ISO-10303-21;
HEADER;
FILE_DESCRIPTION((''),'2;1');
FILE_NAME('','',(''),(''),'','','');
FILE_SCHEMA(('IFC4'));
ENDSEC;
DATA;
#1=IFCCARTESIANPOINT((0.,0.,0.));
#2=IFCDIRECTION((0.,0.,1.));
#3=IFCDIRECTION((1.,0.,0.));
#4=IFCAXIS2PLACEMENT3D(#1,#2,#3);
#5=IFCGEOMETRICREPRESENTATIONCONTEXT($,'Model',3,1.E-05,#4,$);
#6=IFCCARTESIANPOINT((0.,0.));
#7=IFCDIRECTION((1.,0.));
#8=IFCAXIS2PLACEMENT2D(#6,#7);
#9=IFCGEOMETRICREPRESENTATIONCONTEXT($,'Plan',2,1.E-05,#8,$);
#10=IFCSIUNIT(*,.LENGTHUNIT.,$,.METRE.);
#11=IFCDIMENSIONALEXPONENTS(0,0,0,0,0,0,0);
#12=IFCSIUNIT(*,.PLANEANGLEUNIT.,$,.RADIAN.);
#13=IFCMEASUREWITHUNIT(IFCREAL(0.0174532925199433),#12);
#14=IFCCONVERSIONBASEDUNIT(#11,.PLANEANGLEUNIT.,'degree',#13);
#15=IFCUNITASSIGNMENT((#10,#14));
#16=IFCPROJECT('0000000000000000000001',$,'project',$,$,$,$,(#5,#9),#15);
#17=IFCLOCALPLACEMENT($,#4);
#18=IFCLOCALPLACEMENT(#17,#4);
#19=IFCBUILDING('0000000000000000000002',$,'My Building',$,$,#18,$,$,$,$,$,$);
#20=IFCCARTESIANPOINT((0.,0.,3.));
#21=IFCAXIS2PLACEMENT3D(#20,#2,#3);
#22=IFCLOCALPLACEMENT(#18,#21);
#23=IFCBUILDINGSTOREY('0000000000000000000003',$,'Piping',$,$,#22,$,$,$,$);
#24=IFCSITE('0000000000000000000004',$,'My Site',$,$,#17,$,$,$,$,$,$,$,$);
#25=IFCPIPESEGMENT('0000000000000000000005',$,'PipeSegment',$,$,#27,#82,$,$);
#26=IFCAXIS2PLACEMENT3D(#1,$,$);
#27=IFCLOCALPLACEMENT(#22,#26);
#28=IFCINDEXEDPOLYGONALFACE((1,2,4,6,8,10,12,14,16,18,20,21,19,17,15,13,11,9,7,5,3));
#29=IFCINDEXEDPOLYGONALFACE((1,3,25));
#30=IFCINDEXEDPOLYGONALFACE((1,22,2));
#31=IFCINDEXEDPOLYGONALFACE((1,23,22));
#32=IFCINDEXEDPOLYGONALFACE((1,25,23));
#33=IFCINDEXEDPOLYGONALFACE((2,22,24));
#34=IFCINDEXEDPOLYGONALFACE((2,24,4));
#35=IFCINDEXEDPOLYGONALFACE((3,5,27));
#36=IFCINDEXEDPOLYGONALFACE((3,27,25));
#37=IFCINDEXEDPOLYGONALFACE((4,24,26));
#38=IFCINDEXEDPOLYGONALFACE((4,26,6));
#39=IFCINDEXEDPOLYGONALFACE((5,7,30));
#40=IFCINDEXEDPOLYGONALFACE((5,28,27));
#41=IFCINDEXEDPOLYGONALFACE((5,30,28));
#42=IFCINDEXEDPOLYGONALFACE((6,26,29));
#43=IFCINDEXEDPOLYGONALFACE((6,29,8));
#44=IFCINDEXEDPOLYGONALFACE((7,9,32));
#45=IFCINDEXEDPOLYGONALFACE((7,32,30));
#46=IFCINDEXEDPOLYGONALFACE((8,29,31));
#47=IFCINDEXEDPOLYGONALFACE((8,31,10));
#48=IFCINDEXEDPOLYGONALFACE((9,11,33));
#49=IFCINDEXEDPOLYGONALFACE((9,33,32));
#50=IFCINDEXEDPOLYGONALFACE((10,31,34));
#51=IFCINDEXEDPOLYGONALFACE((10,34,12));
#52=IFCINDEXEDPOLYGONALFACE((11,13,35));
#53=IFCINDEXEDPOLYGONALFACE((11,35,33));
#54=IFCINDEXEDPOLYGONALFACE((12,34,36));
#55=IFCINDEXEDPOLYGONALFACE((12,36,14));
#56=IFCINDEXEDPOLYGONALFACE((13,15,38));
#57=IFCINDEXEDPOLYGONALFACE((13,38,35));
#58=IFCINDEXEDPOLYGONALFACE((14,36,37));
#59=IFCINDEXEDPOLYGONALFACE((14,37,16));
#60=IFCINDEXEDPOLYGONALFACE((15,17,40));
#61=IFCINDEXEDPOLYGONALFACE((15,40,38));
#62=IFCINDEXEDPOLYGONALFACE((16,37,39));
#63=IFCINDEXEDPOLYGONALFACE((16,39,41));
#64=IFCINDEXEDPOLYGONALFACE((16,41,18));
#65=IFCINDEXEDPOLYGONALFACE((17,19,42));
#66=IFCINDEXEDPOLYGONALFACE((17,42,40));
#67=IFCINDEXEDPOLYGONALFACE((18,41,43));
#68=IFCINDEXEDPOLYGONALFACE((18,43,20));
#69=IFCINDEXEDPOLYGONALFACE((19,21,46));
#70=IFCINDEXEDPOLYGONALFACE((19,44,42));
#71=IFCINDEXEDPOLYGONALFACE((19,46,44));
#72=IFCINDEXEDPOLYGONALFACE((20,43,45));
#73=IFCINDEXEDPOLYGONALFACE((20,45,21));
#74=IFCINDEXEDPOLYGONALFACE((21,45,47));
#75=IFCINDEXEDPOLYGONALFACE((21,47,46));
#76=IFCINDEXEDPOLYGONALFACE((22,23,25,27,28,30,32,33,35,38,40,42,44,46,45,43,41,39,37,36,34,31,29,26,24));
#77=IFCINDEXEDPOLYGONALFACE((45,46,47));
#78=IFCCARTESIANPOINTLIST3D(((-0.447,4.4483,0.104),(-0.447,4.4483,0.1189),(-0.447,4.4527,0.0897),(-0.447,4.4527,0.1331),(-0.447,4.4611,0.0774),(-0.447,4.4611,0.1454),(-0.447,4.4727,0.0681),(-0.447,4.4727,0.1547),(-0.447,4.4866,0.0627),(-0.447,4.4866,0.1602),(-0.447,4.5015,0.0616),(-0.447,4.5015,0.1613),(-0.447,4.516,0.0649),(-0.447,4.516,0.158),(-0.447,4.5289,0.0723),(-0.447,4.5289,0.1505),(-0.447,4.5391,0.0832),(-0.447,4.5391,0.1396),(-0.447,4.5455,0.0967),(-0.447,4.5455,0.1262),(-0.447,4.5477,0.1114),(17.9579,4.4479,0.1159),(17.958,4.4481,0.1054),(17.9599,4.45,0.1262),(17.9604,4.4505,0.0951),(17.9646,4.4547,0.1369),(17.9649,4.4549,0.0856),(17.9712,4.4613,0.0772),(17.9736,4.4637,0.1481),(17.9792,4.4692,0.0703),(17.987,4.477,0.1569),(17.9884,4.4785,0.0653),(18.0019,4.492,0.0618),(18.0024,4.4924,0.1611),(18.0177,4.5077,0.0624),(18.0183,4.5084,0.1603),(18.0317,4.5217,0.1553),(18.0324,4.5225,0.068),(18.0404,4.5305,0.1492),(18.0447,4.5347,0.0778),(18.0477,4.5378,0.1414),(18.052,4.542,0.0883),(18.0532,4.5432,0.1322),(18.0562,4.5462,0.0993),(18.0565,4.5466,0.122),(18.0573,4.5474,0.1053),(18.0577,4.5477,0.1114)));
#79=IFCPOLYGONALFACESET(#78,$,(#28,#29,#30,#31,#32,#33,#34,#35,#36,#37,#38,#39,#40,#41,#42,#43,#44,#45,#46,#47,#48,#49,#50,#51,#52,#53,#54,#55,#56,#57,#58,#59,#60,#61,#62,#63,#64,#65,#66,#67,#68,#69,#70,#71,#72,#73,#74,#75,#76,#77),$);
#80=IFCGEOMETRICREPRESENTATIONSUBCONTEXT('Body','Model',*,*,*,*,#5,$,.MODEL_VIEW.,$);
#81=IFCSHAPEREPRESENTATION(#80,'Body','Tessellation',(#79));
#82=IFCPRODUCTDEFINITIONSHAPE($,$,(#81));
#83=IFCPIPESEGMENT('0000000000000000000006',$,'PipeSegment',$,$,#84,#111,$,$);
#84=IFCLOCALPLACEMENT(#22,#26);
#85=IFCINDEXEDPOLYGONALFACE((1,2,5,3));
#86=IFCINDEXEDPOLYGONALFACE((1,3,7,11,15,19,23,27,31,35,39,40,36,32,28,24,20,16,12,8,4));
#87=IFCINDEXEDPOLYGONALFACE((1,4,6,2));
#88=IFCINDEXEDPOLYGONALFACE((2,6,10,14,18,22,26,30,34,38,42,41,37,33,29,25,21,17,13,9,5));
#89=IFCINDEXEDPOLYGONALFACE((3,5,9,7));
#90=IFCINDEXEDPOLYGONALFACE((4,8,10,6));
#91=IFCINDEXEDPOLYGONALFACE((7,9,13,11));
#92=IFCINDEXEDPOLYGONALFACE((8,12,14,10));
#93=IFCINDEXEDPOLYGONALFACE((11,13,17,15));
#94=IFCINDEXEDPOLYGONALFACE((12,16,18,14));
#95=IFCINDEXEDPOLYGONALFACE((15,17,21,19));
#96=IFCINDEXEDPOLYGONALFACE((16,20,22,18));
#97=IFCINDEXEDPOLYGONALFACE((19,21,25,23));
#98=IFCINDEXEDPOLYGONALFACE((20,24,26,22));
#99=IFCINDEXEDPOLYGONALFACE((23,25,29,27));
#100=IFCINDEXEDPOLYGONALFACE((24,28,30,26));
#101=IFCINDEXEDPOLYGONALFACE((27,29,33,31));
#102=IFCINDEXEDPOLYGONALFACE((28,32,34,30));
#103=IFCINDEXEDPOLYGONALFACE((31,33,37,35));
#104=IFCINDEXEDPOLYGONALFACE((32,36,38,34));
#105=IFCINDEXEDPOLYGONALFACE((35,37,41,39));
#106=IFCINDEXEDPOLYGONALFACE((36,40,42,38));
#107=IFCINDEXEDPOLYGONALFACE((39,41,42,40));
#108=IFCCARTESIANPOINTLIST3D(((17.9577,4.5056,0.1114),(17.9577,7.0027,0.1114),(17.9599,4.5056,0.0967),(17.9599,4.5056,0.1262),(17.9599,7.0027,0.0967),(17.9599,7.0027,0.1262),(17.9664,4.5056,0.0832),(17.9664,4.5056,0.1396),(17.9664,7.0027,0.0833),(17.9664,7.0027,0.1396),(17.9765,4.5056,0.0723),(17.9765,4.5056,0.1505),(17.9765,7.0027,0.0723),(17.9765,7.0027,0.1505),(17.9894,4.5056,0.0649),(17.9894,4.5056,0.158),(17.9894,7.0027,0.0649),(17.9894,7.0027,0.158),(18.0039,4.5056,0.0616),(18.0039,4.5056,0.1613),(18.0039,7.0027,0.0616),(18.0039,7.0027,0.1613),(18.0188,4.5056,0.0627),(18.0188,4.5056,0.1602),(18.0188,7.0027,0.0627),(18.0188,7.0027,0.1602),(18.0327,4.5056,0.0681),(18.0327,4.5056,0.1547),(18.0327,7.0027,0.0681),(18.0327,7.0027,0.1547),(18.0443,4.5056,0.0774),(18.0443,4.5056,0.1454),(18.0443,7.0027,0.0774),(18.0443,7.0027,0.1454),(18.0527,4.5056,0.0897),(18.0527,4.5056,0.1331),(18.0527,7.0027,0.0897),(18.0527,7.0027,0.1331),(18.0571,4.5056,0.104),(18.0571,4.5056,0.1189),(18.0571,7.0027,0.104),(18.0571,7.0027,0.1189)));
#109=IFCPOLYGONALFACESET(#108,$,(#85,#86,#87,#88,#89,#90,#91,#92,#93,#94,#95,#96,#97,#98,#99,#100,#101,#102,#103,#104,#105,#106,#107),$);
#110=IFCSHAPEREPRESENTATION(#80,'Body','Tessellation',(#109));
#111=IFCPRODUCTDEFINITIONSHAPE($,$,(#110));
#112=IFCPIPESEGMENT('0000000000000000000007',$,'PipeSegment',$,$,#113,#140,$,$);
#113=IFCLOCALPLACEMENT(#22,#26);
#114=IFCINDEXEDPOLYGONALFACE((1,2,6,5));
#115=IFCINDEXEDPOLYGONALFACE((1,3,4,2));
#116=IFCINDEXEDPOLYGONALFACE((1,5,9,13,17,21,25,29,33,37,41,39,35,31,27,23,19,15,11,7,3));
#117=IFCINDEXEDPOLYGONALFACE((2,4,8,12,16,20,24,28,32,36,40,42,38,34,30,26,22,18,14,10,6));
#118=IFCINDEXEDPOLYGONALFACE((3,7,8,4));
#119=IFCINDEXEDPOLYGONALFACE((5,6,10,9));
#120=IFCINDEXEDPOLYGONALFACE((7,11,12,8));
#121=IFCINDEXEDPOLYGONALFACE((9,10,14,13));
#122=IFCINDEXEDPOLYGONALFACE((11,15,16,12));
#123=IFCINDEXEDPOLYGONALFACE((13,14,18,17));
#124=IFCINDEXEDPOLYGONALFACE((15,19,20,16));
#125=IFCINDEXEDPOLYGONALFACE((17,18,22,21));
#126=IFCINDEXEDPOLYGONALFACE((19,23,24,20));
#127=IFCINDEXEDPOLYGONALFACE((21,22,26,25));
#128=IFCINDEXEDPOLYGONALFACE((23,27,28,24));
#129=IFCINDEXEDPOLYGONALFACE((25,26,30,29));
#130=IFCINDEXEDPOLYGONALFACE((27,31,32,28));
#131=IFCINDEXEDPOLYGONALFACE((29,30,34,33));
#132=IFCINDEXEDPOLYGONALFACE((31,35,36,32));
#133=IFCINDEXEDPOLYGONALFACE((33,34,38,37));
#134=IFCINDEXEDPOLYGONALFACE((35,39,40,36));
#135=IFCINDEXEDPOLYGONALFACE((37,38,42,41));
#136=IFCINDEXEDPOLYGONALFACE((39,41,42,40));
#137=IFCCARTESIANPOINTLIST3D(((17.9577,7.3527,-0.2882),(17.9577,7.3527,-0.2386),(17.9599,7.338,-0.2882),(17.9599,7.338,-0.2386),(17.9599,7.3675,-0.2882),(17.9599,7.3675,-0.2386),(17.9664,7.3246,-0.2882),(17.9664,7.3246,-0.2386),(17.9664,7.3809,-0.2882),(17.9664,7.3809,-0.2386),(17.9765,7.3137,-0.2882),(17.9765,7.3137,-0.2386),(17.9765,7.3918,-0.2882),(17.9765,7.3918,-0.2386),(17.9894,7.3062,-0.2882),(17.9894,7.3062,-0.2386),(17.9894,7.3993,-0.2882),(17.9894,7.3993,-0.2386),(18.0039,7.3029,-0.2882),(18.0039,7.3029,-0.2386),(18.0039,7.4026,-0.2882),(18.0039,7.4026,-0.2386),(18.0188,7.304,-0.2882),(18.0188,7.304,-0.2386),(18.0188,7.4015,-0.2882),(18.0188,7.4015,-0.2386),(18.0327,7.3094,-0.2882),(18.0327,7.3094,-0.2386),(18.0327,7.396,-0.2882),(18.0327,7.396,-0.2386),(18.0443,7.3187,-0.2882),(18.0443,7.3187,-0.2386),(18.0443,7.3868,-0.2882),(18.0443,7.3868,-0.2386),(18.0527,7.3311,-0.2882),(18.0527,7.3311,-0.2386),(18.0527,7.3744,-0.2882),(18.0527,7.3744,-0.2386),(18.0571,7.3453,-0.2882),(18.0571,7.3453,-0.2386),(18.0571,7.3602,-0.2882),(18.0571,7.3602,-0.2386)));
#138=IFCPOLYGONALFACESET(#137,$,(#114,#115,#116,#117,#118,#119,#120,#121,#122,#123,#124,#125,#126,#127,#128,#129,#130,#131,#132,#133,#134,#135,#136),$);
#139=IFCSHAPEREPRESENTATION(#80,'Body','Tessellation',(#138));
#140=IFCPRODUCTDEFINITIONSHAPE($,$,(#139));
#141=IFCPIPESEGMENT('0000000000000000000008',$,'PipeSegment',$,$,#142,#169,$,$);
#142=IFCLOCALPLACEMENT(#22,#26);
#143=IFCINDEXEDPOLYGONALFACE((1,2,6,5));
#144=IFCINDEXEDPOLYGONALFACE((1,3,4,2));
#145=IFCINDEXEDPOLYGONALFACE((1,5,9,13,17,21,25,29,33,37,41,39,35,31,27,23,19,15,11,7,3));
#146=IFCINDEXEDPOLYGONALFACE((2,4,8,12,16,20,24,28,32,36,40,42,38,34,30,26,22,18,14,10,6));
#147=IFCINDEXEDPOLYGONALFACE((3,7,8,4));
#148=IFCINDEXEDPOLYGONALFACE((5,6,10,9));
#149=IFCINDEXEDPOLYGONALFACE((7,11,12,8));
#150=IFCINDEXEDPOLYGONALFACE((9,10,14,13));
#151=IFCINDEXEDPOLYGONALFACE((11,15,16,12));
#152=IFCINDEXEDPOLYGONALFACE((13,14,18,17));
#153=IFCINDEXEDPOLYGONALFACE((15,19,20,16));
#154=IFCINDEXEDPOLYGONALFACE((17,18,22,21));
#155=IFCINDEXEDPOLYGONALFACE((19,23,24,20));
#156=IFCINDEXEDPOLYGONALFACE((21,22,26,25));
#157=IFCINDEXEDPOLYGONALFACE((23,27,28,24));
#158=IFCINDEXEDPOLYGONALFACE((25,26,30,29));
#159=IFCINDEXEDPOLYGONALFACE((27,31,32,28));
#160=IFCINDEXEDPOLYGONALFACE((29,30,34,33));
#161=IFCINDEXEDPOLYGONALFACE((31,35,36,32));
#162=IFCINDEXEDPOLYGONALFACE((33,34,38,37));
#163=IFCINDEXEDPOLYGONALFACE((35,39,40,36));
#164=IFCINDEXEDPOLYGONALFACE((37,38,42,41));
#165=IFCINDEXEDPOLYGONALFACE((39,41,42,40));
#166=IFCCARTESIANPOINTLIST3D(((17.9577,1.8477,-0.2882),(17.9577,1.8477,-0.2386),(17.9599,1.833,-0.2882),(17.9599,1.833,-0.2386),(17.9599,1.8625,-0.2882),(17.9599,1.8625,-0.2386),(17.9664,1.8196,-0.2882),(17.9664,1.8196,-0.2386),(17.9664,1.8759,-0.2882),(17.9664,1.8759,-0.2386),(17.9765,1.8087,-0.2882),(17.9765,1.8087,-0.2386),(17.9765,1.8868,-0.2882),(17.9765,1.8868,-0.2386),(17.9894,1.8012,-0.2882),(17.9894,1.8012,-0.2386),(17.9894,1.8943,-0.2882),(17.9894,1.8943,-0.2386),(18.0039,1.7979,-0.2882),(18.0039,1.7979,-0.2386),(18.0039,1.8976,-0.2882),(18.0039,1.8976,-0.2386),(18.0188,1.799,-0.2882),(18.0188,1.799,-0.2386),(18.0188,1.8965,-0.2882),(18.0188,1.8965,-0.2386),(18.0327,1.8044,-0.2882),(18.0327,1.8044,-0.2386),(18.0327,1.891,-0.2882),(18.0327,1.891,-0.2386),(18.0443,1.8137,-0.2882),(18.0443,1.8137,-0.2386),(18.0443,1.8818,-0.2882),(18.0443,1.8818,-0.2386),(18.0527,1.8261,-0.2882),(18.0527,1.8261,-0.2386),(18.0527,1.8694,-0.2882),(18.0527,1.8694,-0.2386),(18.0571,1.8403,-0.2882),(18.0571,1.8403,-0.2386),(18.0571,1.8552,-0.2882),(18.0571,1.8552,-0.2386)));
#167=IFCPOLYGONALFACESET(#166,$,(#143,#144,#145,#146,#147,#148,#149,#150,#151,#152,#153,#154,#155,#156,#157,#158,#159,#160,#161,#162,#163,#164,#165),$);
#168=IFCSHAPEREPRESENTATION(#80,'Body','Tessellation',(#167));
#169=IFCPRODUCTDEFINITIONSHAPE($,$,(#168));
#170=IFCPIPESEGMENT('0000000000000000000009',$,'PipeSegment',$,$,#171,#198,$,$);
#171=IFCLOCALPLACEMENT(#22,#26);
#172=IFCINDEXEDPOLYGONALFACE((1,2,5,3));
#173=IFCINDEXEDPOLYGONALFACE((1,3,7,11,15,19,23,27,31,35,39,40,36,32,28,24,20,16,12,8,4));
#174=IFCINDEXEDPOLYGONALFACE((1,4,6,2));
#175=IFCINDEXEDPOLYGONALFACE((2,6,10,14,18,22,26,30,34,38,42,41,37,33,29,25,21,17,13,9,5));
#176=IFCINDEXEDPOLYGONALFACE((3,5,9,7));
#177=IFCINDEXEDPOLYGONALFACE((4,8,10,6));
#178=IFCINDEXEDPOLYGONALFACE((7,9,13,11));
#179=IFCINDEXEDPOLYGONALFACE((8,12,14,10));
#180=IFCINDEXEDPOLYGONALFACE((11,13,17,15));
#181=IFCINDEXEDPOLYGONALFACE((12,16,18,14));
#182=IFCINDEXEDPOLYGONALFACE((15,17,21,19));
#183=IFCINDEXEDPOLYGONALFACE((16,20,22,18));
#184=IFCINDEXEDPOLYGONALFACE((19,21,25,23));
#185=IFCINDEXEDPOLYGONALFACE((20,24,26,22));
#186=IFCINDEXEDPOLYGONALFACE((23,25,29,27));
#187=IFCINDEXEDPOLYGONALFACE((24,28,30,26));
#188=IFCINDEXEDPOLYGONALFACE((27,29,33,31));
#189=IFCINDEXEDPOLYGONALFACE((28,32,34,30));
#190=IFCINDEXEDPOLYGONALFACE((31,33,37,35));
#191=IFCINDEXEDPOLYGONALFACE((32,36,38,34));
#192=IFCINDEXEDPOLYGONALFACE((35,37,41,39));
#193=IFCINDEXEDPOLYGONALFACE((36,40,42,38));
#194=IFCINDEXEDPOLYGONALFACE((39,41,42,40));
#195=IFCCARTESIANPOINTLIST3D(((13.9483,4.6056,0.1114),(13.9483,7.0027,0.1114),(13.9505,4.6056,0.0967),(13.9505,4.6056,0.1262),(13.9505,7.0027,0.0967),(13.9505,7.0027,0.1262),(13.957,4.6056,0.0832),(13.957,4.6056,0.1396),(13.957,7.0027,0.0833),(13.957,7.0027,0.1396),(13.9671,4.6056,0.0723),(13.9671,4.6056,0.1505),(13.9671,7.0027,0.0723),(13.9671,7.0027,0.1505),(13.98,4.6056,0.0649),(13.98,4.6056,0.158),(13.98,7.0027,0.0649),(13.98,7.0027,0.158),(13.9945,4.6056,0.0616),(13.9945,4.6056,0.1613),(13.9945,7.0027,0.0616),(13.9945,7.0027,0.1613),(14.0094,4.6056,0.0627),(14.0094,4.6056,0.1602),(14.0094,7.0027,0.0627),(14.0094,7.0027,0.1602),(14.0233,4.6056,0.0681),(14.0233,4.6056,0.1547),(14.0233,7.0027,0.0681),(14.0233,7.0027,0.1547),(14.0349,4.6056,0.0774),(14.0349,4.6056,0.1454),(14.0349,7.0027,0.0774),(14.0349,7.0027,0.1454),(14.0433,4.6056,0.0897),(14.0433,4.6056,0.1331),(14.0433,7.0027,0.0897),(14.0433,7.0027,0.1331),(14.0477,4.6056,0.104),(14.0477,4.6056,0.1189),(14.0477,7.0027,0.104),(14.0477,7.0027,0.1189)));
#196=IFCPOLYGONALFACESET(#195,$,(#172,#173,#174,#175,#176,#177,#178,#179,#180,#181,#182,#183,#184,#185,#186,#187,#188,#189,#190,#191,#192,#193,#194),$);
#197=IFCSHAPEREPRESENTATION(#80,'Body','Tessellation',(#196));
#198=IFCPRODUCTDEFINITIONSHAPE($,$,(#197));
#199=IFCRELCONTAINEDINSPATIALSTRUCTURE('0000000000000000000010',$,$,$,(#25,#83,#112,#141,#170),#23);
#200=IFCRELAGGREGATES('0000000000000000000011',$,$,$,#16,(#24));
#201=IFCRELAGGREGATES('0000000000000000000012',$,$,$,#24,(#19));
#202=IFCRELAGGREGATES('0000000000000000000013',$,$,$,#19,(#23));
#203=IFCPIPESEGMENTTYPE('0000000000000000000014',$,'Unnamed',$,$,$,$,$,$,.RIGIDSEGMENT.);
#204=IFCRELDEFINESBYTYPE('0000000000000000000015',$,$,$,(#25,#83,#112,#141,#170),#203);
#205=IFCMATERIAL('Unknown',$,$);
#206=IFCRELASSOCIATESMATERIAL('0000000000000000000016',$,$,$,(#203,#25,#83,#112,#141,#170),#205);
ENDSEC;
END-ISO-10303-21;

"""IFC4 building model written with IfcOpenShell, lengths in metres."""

from ifc_helpers import new_model, entity, si_unit, converted_unit, frame, origin_with_axes, origin_2d_with_axis, place, context, subcontext, project, spatial, circle, extrude, clip, halfspace, material, material_profile, profile_set, profile_usage, type_object, element, save


model = new_model("IFC4")

# Units and contexts
model_context = context("Model", 3, precision=1e-05, world=origin_with_axes())
plan_context = context("Plan", 2, precision=1e-05, world=origin_2d_with_axis())
body_context = subcontext(model_context, "Body", "Model", "MODEL_VIEW")
ifc_project = project(units=[si_unit("LENGTHUNIT", "METRE"), converted_unit("PLANEANGLEUNIT", "degree", entity("IfcReal", 0.0174532925199433), si_unit("PLANEANGLEUNIT", "RADIAN"), dimensions=[0, 0, 0, 0, 0, 0, 0])], contexts=[model_context, plan_context])

# Site, building, storey
site_placement = place(None, origin_with_axes())
site = spatial("IfcSite", under=ifc_project, at=site_placement, Name="My Site")
building_placement = place(site_placement, origin_with_axes())
building = spatial("IfcBuilding", under=site, at=building_placement, Name="My Building")
storey_placement = place(building_placement, frame((0.0, 0.0, 3.0), z_axis=(0.0, 0.0, 1.0), x_axis=(1.0, 0.0, 0.0)))
storey = spatial("IfcBuildingStorey", under=building, at=storey_placement, Name="Piping")

# Pipe segments
ifc_material = material(Name="Unknown")
ifc_material_profile_1 = material_profile(ifc_material, circle(Radius=0.05))
ifc_profile_set_1 = profile_set([ifc_material_profile_1])
ifc_profile_usage_1 = profile_usage(ifc_profile_set_1, cardinal=16)
pipe_segment_type = type_object("IfcPipeSegmentType", Name="Unnamed", PredefinedType="RIGIDSEGMENT", material=ifc_profile_set_1)
pipe_segment_1_placement = place(storey_placement, frame((-0.447, 4.4977, 0.1114), z_axis=(1.0, 0.0, 0.0), x_axis=(0.0, 1.0, 0.0)))
element("IfcPipeSegment", 1, at=pipe_segment_1_placement, inside=storey, type_object=pipe_segment_type, material=ifc_profile_usage_1, Name="PipeSegment", context=body_context, shape_type="Clipping", body=[
    clip(extrude(circle(Radius=0.05), origin_with_axes(), (0.0, 0.0, 1.0), 18.5047), halfspace(frame((0.05, -3.1114, 18.5046), z_axis=(-0.7071, 0.0, 0.707114), x_axis=(0.0, 1.0, 0.0)), False)),
])
ifc_profile_usage_2 = profile_usage(ifc_profile_set_1, cardinal=16)
pipe_segment_2_placement = place(storey_placement, frame((18.0077, 4.5056, 0.1114), z_axis=(0.0, 1.0, 0.0), x_axis=(-1.0, 0.0, 0.0)))
element("IfcPipeSegment", 2, at=pipe_segment_2_placement, inside=storey, type_object=pipe_segment_type, material=ifc_profile_usage_2, Name="PipeSegment", context=body_context, shape_type="SweptSolid", body=[
    extrude(circle(Radius=0.05), origin_with_axes(), (0.0, 0.0, 1.0), 2.4972),
])
ifc_profile_usage_3 = profile_usage(ifc_profile_set_1, cardinal=16)
pipe_segment_3_placement = place(storey_placement, frame((18.0077, 7.3527, -0.2386), z_axis=(0.0, 0.0, -1.0), x_axis=(-1.0, 0.0, 0.0)))
element("IfcPipeSegment", 3, at=pipe_segment_3_placement, inside=storey, type_object=pipe_segment_type, material=ifc_profile_usage_3, Name="PipeSegment", context=body_context, shape_type="SweptSolid", body=[
    extrude(circle(Radius=0.05), origin_with_axes(), (0.0, 0.0, 1.0), 0.0496),
])
ifc_profile_usage_4 = profile_usage(ifc_profile_set_1, cardinal=16)
pipe_segment_4_placement = place(storey_placement, frame((18.0077, 1.8477, -0.2386), z_axis=(0.0, 0.0, -1.0), x_axis=(-1.0, 0.0, 0.0)))
element("IfcPipeSegment", 4, at=pipe_segment_4_placement, inside=storey, type_object=pipe_segment_type, material=ifc_profile_usage_4, Name="PipeSegment", context=body_context, shape_type="SweptSolid", body=[
    extrude(circle(Radius=0.05), origin_with_axes(), (0.0, 0.0, 1.0), 0.0496),
])
ifc_profile_usage_5 = profile_usage(ifc_profile_set_1, cardinal=16)
pipe_segment_5_placement = place(storey_placement, frame((13.9983, 4.6056, 0.1114), z_axis=(0.0, 1.0, 0.0), x_axis=(-1.0, 0.0, 0.0)))
element("IfcPipeSegment", 5, at=pipe_segment_5_placement, inside=storey, type_object=pipe_segment_type, material=ifc_profile_usage_5, Name="PipeSegment", context=body_context, shape_type="SweptSolid", body=[
    extrude(circle(Radius=0.05), origin_with_axes(), (0.0, 0.0, 1.0), 2.3972),
])

save(model, "model.ifc")
